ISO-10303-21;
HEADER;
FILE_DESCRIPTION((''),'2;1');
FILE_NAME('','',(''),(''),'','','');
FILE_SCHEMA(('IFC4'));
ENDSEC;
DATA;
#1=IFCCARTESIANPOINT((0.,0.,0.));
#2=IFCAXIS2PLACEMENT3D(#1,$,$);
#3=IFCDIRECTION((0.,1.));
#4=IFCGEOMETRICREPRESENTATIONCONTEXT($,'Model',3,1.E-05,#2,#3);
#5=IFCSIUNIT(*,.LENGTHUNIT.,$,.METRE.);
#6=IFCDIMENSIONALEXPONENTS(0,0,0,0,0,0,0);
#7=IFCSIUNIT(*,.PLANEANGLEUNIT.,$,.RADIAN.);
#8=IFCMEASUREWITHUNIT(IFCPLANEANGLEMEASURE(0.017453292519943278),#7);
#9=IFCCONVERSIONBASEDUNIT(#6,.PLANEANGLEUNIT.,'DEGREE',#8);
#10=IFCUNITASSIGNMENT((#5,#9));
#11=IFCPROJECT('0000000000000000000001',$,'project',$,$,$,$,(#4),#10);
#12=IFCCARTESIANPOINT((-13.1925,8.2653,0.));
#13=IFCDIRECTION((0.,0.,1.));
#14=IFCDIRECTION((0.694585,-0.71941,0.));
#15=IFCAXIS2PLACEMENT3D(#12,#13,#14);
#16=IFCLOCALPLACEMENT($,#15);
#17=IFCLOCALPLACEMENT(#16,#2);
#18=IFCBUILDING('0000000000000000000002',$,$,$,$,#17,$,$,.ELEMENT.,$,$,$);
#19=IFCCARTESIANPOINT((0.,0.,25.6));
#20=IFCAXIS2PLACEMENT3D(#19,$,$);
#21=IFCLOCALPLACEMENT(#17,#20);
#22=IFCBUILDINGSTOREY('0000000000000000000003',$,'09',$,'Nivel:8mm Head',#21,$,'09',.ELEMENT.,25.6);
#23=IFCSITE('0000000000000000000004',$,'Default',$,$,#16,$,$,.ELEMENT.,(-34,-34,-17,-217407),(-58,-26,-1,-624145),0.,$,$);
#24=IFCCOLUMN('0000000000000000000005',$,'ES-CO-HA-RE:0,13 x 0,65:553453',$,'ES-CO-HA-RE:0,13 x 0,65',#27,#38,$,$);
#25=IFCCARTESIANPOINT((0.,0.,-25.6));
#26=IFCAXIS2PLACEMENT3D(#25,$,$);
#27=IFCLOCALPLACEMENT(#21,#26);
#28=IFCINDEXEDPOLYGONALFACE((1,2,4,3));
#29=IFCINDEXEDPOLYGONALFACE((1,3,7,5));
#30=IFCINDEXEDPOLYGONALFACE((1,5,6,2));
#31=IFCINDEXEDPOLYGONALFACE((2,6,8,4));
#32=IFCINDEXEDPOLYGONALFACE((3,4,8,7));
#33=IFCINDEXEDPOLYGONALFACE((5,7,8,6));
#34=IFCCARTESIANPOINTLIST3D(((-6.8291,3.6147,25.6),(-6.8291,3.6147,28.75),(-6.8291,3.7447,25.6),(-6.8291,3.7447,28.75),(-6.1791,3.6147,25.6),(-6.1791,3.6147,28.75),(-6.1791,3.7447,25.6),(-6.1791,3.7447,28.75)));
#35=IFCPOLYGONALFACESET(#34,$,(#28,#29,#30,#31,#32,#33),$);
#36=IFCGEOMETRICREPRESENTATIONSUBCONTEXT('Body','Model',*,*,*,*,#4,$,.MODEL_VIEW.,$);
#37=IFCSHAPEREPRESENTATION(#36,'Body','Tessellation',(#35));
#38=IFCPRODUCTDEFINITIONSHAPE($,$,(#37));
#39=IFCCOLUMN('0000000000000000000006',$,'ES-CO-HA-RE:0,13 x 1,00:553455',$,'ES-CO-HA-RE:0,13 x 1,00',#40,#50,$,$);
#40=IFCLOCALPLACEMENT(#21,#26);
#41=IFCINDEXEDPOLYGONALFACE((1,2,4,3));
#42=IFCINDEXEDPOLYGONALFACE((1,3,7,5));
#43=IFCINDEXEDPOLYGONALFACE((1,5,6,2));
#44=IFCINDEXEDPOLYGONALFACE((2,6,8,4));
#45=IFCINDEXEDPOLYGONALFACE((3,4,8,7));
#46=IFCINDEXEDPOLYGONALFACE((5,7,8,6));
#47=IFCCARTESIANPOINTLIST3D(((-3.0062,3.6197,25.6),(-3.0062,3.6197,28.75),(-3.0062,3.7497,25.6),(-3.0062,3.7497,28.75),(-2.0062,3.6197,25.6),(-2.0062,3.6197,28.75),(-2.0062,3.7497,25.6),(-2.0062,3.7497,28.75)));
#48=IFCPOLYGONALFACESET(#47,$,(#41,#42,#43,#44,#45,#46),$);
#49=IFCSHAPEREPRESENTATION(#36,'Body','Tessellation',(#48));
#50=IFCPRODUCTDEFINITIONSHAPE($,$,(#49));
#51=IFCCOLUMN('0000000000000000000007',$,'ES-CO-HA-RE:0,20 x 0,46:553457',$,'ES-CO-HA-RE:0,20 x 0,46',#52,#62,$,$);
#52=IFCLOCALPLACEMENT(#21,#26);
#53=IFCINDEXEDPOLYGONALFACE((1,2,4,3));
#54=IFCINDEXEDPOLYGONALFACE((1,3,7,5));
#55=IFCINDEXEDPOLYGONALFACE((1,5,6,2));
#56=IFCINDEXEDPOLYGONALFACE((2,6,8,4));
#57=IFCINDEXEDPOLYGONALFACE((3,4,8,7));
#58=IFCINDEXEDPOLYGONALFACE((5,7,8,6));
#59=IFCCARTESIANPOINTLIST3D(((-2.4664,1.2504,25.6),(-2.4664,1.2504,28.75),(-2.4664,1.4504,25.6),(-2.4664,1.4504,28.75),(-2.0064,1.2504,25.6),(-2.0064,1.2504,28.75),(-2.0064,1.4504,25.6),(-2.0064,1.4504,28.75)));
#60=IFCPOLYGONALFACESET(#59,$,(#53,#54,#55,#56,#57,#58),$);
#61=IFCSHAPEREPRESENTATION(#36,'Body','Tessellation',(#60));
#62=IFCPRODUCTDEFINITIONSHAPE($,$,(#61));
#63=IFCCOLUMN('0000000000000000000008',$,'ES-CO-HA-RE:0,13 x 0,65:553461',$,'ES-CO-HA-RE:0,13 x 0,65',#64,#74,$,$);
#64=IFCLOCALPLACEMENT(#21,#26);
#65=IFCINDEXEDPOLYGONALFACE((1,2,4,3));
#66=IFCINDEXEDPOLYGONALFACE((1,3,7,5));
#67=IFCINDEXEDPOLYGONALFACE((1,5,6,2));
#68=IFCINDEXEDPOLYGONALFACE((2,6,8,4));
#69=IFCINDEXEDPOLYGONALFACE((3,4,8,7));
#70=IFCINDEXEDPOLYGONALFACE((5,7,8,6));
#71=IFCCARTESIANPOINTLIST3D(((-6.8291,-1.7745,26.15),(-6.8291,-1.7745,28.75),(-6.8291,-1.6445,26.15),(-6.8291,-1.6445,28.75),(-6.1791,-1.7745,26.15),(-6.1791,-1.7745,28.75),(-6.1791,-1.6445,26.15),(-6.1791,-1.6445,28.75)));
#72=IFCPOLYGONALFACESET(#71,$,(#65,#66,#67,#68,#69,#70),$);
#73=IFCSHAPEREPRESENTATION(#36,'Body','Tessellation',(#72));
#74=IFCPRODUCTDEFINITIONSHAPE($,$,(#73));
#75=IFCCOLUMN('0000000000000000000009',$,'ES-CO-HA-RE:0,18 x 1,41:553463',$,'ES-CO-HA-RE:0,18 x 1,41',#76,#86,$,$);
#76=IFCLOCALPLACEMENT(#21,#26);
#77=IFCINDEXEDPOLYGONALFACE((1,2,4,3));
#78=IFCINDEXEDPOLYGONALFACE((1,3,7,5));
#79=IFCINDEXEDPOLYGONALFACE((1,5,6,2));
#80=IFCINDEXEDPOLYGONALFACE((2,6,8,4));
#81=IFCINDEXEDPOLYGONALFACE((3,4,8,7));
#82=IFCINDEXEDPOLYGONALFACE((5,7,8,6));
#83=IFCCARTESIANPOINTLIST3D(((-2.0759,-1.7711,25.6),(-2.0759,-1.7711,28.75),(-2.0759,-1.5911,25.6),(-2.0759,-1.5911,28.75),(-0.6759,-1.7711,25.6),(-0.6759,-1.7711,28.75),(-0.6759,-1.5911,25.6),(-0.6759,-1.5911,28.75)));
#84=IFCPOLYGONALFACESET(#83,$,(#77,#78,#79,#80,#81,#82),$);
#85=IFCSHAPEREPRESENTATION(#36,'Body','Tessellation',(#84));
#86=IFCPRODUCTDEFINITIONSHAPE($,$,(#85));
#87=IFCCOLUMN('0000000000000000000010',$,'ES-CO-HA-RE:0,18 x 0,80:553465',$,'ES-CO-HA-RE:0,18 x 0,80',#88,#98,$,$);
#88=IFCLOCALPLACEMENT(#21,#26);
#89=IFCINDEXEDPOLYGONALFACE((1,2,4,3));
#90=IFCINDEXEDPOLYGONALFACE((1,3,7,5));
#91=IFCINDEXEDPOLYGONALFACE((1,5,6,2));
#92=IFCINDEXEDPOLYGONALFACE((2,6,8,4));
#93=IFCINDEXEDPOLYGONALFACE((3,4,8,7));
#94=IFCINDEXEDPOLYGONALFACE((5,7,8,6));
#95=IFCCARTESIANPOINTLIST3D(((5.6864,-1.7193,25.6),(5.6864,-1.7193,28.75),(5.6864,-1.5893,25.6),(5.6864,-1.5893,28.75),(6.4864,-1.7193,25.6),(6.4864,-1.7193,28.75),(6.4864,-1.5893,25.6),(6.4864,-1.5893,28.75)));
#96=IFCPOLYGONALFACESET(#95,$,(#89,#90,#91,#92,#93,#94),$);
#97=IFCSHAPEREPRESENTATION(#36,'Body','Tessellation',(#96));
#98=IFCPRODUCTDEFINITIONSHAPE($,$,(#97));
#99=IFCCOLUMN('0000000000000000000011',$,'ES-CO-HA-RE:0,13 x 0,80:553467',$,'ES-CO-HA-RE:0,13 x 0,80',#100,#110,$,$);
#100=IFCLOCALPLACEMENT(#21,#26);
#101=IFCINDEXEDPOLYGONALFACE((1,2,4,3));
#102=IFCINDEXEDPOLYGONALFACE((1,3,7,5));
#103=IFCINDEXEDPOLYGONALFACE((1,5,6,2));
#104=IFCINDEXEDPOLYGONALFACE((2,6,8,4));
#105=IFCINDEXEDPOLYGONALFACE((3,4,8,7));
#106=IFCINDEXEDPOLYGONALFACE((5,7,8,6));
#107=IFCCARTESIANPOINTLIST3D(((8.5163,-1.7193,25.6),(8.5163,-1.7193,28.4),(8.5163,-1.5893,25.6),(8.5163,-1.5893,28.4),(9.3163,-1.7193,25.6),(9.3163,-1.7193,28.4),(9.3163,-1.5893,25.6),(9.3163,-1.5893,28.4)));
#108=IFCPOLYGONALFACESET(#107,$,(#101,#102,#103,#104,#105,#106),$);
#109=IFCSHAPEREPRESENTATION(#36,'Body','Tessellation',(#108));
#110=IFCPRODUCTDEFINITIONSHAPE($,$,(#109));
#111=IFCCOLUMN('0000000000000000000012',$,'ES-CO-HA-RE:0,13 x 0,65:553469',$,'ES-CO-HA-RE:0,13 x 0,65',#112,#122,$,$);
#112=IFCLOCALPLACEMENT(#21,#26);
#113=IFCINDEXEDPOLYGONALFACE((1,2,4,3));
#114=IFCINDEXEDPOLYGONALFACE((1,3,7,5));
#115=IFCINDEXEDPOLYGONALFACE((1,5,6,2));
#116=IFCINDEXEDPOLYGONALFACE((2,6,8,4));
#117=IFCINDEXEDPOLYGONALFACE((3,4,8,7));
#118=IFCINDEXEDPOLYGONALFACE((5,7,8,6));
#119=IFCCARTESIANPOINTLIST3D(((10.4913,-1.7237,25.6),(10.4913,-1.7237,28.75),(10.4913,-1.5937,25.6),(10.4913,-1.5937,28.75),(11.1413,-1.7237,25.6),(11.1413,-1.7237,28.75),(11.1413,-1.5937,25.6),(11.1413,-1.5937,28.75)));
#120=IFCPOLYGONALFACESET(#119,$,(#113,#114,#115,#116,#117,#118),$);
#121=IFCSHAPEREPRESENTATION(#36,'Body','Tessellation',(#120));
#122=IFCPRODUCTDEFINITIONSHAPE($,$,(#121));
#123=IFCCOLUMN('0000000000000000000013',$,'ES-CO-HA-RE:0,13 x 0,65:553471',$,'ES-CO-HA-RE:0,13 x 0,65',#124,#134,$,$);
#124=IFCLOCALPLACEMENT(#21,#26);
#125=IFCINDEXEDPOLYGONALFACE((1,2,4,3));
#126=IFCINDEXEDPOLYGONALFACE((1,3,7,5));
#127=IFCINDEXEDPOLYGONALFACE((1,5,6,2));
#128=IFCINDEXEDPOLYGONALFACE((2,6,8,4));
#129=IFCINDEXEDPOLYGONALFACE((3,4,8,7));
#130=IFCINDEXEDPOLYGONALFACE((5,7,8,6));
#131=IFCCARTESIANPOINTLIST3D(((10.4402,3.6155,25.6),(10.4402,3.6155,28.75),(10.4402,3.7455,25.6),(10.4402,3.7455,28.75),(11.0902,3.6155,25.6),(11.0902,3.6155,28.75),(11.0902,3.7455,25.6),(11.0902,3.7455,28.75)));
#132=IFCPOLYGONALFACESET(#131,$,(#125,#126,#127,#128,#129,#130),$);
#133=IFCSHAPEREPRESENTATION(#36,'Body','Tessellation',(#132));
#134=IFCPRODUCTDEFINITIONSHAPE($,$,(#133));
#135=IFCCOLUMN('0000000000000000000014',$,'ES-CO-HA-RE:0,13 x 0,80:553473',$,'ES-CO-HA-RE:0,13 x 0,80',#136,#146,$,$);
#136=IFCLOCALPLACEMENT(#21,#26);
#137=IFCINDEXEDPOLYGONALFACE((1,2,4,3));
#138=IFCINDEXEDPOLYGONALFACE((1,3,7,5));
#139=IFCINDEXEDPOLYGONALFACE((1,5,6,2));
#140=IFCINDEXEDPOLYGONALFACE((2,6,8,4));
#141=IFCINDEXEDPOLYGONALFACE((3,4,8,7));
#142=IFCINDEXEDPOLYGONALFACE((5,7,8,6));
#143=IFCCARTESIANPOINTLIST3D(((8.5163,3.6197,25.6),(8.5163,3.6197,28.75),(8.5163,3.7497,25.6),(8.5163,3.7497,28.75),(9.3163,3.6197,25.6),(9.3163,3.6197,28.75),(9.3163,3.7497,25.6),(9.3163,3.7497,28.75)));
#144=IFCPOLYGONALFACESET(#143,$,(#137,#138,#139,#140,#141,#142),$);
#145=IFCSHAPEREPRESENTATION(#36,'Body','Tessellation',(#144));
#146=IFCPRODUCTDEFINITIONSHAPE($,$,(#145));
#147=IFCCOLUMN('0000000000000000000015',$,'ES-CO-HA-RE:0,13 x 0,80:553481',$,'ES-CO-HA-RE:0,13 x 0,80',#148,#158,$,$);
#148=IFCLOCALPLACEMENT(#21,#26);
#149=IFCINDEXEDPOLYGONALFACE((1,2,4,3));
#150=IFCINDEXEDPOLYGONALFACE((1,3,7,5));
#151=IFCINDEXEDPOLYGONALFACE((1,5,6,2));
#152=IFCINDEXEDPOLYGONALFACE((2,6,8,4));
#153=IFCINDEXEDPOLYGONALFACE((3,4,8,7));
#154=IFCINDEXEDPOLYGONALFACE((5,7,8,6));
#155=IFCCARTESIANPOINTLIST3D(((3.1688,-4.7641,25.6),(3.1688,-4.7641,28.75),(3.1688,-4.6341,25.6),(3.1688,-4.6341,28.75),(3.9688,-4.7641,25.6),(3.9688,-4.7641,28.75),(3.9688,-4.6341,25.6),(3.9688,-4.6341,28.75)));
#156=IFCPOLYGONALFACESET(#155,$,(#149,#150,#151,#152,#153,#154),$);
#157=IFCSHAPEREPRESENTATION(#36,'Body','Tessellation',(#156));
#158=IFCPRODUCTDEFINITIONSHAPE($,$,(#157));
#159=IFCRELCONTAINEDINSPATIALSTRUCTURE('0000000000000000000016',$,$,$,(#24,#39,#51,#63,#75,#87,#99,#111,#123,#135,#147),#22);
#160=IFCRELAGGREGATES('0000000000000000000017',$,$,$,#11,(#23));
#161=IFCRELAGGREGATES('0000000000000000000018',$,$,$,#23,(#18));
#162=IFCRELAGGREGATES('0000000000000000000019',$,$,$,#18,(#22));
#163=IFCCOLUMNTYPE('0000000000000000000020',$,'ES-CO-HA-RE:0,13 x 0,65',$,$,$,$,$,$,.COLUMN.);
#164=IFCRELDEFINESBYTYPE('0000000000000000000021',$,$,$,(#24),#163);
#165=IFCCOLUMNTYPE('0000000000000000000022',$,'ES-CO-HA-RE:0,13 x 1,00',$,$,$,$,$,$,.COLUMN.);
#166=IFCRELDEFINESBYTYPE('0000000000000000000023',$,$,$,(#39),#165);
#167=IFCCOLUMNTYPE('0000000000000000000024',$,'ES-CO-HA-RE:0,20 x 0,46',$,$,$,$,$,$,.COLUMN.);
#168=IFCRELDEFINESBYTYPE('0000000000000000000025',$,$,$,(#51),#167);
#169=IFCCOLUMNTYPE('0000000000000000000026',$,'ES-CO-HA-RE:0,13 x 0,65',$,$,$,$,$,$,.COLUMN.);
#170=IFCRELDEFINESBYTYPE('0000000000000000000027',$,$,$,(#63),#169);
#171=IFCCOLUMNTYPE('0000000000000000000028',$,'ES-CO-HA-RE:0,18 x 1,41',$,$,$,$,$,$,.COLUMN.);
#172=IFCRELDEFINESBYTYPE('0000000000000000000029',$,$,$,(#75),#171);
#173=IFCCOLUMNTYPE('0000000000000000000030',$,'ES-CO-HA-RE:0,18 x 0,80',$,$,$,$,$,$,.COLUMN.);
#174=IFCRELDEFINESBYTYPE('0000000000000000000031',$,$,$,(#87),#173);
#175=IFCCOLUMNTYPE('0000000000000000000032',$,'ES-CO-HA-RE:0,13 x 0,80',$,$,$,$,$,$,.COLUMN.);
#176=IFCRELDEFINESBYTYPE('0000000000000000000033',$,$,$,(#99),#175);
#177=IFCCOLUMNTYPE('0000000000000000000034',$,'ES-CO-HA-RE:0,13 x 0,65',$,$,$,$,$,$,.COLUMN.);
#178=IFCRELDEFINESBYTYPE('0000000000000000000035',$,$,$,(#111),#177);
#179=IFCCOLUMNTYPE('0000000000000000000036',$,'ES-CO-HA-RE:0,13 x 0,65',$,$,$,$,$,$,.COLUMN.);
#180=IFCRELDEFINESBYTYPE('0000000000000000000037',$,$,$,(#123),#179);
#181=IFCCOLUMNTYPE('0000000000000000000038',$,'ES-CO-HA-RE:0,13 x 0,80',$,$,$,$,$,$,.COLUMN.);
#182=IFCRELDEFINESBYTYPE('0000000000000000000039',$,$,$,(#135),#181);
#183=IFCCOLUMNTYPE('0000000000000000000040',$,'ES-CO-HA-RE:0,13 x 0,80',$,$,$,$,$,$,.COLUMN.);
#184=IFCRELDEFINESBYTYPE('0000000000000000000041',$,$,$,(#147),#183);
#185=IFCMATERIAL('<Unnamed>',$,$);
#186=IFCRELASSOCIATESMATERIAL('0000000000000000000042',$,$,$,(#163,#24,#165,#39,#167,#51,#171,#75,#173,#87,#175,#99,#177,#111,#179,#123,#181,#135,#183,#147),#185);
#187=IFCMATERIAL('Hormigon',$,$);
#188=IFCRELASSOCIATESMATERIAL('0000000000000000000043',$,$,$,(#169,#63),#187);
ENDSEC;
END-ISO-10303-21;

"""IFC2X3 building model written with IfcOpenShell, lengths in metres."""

from ifc_helpers import new_model, entity, si_unit, converted_unit, direction, frame, frame_2d, origin, origin_2d_with_axis, place, context, subcontext, project, spatial, rectangle, extrude, source, transform, mapped, material, type_object, type_shapes, element, save


model = new_model("IFC2X3")

# Units and contexts
model_context = context("Model", 3, precision=1e-05, world=origin(), true_north=direction((0.0, 1.0)))
body_context = subcontext(model_context, "Body", "Model", "MODEL_VIEW")
ifc_project = project(units=[si_unit("LENGTHUNIT", "METRE"), converted_unit("PLANEANGLEUNIT", "DEGREE", entity("IfcPlaneAngleMeasure", 0.017453292519943278), si_unit("PLANEANGLEUNIT", "RADIAN"), dimensions=[0, 0, 0, 0, 0, 0, 0])], contexts=[model_context])

# Site, building, storey
site_placement = place(None, frame((-13.1925, 8.2653, 0.0), z_axis=(0.0, 0.0, 1.0), x_axis=(0.694585, -0.71941, 0.0)))
site = spatial("IfcSite", under=ifc_project, at=site_placement, Name="Default", CompositionType="ELEMENT", RefLatitude=(-34, -34, -17, -217407), RefLongitude=(-58, -26, -1, -624145), RefElevation=0.0)
building_placement = place(site_placement, origin())
building = spatial("IfcBuilding", under=site, at=building_placement, CompositionType="ELEMENT")
storey_placement = place(building_placement, frame((0.0, 0.0, 25.6)))
storey = spatial("IfcBuildingStorey", under=building, at=storey_placement, Name="09", ObjectType="Nivel:8mm Head", LongName="09", CompositionType="ELEMENT", Elevation=25.6)

# Columns
ifc_material_1 = material(Name="<Unnamed>")
column_type_1 = type_object("IfcColumnType", Name="ES-CO-HA-RE:0,13 x 0,65", PredefinedType="COLUMN", material=ifc_material_1)
shared_shape_1 = source(origin(), body_context, "Body", "SweptSolid", [
    extrude(rectangle(XDim=0.65, YDim=0.13, at=origin_2d_with_axis()), frame((-6.5041, 3.6797, 25.6), z_axis=(0.0, 0.0, 1.0), x_axis=(-1.0, 0.0, 0.0)), (0.0, 0.0, 1.0), 3.15),
])
type_shapes(column_type_1, [shared_shape_1])
column_1_placement = place(storey_placement, frame((0.0, 0.0, -25.6)))
element("IfcColumn", 1, at=column_1_placement, inside=storey, type_object=column_type_1, material=ifc_material_1, Name="ES-CO-HA-RE:0,13 x 0,65:553453", ObjectType="ES-CO-HA-RE:0,13 x 0,65", context=body_context, shape_type="MappedRepresentation", body=[
    mapped(shared_shape_1, transform((0.0, 0.0, 0.0), scale=1.0)),
])
column_type_2 = type_object("IfcColumnType", Name="ES-CO-HA-RE:0,13 x 1,00", PredefinedType="COLUMN", material=ifc_material_1)
shared_shape_2 = source(origin(), body_context, "Body", "SweptSolid", [
    extrude(rectangle(XDim=1.0, YDim=0.13, at=frame_2d((0.0, 0.0), x_axis=(1.0, 0.0))), frame((-2.5062, 3.6847, 25.6), z_axis=(0.0, 0.0, 1.0), x_axis=(-1.0, 0.0, 0.0)), (0.0, 0.0, 1.0), 3.15),
])
type_shapes(column_type_2, [shared_shape_2])
column_2_placement = place(storey_placement, frame((0.0, 0.0, -25.6)))
element("IfcColumn", 2, at=column_2_placement, inside=storey, type_object=column_type_2, material=ifc_material_1, Name="ES-CO-HA-RE:0,13 x 1,00:553455", ObjectType="ES-CO-HA-RE:0,13 x 1,00", context=body_context, shape_type="MappedRepresentation", body=[
    mapped(shared_shape_2, transform((0.0, 0.0, 0.0), scale=1.0)),
])
column_type_3 = type_object("IfcColumnType", Name="ES-CO-HA-RE:0,20 x 0,46", PredefinedType="COLUMN", material=ifc_material_1)
shared_shape_3 = source(origin(), body_context, "Body", "SweptSolid", [
    extrude(rectangle(XDim=0.46, YDim=0.2, at=frame_2d((0.0, 0.0), x_axis=(1.0, 0.0))), frame((-2.2364, 1.3504, 25.6), z_axis=(0.0, 0.0, 1.0), x_axis=(-1.0, 0.0, 0.0)), (0.0, 0.0, 1.0), 3.15),
])
type_shapes(column_type_3, [shared_shape_3])
column_3_placement = place(storey_placement, frame((0.0, 0.0, -25.6)))
element("IfcColumn", 3, at=column_3_placement, inside=storey, type_object=column_type_3, material=ifc_material_1, Name="ES-CO-HA-RE:0,20 x 0,46:553457", ObjectType="ES-CO-HA-RE:0,20 x 0,46", context=body_context, shape_type="MappedRepresentation", body=[
    mapped(shared_shape_3, transform((0.0, 0.0, 0.0), scale=1.0)),
])
ifc_material_2 = material(Name="Hormigon")
column_type_4 = type_object("IfcColumnType", Name="ES-CO-HA-RE:0,13 x 0,65", PredefinedType="COLUMN", material=ifc_material_2)
shared_shape_4 = source(origin(), body_context, "Body", "SweptSolid", [
    extrude(rectangle(XDim=0.65, YDim=0.13, at=frame_2d((0.0, 0.0), x_axis=(1.0, 0.0))), frame((-6.5041, -1.7095, 26.15), z_axis=(0.0, 0.0, 1.0), x_axis=(-1.0, 0.0, 0.0)), (0.0, 0.0, 1.0), 2.6),
])
type_shapes(column_type_4, [shared_shape_4])
column_4_placement = place(storey_placement, frame((0.0, 0.0, -25.6)))
element("IfcColumn", 4, at=column_4_placement, inside=storey, type_object=column_type_4, material=ifc_material_2, Name="ES-CO-HA-RE:0,13 x 0,65:553461", ObjectType="ES-CO-HA-RE:0,13 x 0,65", context=body_context, shape_type="MappedRepresentation", body=[
    mapped(shared_shape_4, transform((0.0, 0.0, 0.0), scale=1.0)),
])
column_type_5 = type_object("IfcColumnType", Name="ES-CO-HA-RE:0,18 x 1,41", PredefinedType="COLUMN", material=ifc_material_1)
shared_shape_5 = source(origin(), body_context, "Body", "SweptSolid", [
    extrude(rectangle(XDim=1.4, YDim=0.18, at=frame_2d((0.0, 0.0), x_axis=(1.0, 0.0))), frame((-1.3759, -1.6811, 25.6), z_axis=(0.0, 0.0, 1.0), x_axis=(-1.0, 0.0, 0.0)), (0.0, 0.0, 1.0), 3.15),
])
type_shapes(column_type_5, [shared_shape_5])
column_5_placement = place(storey_placement, frame((0.0, 0.0, -25.6)))
element("IfcColumn", 5, at=column_5_placement, inside=storey, type_object=column_type_5, material=ifc_material_1, Name="ES-CO-HA-RE:0,18 x 1,41:553463", ObjectType="ES-CO-HA-RE:0,18 x 1,41", context=body_context, shape_type="MappedRepresentation", body=[
    mapped(shared_shape_5, transform((0.0, 0.0, 0.0), scale=1.0)),
])
column_type_6 = type_object("IfcColumnType", Name="ES-CO-HA-RE:0,18 x 0,80", PredefinedType="COLUMN", material=ifc_material_1)
shared_shape_6 = source(origin(), body_context, "Body", "SweptSolid", [
    extrude(rectangle(XDim=0.8, YDim=0.13, at=frame_2d((0.0, 0.0), x_axis=(1.0, 0.0))), frame((6.0864, -1.6543, 25.6), z_axis=(0.0, 0.0, 1.0), x_axis=(-1.0, 0.0, 0.0)), (0.0, 0.0, 1.0), 3.15),
])
type_shapes(column_type_6, [shared_shape_6])
column_6_placement = place(storey_placement, frame((0.0, 0.0, -25.6)))
element("IfcColumn", 6, at=column_6_placement, inside=storey, type_object=column_type_6, material=ifc_material_1, Name="ES-CO-HA-RE:0,18 x 0,80:553465", ObjectType="ES-CO-HA-RE:0,18 x 0,80", context=body_context, shape_type="MappedRepresentation", body=[
    mapped(shared_shape_6, transform((0.0, 0.0, 0.0), scale=1.0)),
])
column_type_7 = type_object("IfcColumnType", Name="ES-CO-HA-RE:0,13 x 0,80", PredefinedType="COLUMN", material=ifc_material_1)
shared_shape_7 = source(origin(), body_context, "Body", "SweptSolid", [
    extrude(rectangle(XDim=0.8, YDim=0.13, at=frame_2d((0.0, 0.0), x_axis=(1.0, 0.0))), frame((8.9163, -1.6543, 25.6), z_axis=(0.0, 0.0, 1.0), x_axis=(-1.0, 0.0, 0.0)), (0.0, 0.0, 1.0), 2.8),
])
type_shapes(column_type_7, [shared_shape_7])
column_7_placement = place(storey_placement, frame((0.0, 0.0, -25.6)))
element("IfcColumn", 7, at=column_7_placement, inside=storey, type_object=column_type_7, material=ifc_material_1, Name="ES-CO-HA-RE:0,13 x 0,80:553467", ObjectType="ES-CO-HA-RE:0,13 x 0,80", context=body_context, shape_type="MappedRepresentation", body=[
    mapped(shared_shape_7, transform((0.0, 0.0, 0.0), scale=1.0)),
])
column_type_8 = type_object("IfcColumnType", Name="ES-CO-HA-RE:0,13 x 0,65", PredefinedType="COLUMN", material=ifc_material_1)
shared_shape_8 = source(origin(), body_context, "Body", "SweptSolid", [
    extrude(rectangle(XDim=0.65, YDim=0.13, at=origin_2d_with_axis()), frame((10.8163, -1.6587, 25.6), z_axis=(0.0, 0.0, 1.0), x_axis=(-1.0, 0.0, 0.0)), (0.0, 0.0, 1.0), 3.15),
])
type_shapes(column_type_8, [shared_shape_8])
column_8_placement = place(storey_placement, frame((0.0, 0.0, -25.6)))
element("IfcColumn", 8, at=column_8_placement, inside=storey, type_object=column_type_8, material=ifc_material_1, Name="ES-CO-HA-RE:0,13 x 0,65:553469", ObjectType="ES-CO-HA-RE:0,13 x 0,65", context=body_context, shape_type="MappedRepresentation", body=[
    mapped(shared_shape_8, transform((0.0, 0.0, 0.0), scale=1.0)),
])
column_type_9 = type_object("IfcColumnType", Name="ES-CO-HA-RE:0,13 x 0,65", PredefinedType="COLUMN", material=ifc_material_1)
shared_shape_9 = source(origin(), body_context, "Body", "SweptSolid", [
    extrude(rectangle(XDim=0.65, YDim=0.13, at=origin_2d_with_axis()), frame((10.7652, 3.6805, 25.6), z_axis=(0.0, 0.0, 1.0), x_axis=(-1.0, 0.0, 0.0)), (0.0, 0.0, 1.0), 3.15),
])
type_shapes(column_type_9, [shared_shape_9])
column_9_placement = place(storey_placement, frame((0.0, 0.0, -25.6)))
element("IfcColumn", 9, at=column_9_placement, inside=storey, type_object=column_type_9, material=ifc_material_1, Name="ES-CO-HA-RE:0,13 x 0,65:553471", ObjectType="ES-CO-HA-RE:0,13 x 0,65", context=body_context, shape_type="MappedRepresentation", body=[
    mapped(shared_shape_9, transform((0.0, 0.0, 0.0), scale=1.0)),
])
column_type_10 = type_object("IfcColumnType", Name="ES-CO-HA-RE:0,13 x 0,80", PredefinedType="COLUMN", material=ifc_material_1)
shared_shape_10 = source(origin(), body_context, "Body", "SweptSolid", [
    extrude(rectangle(XDim=0.8, YDim=0.13, at=origin_2d_with_axis()), frame((8.9163, 3.6847, 25.6), z_axis=(0.0, 0.0, 1.0), x_axis=(-1.0, 0.0, 0.0)), (0.0, 0.0, 1.0), 3.15),
])
type_shapes(column_type_10, [shared_shape_10])
column_10_placement = place(storey_placement, frame((0.0, 0.0, -25.6)))
element("IfcColumn", 10, at=column_10_placement, inside=storey, type_object=column_type_10, material=ifc_material_1, Name="ES-CO-HA-RE:0,13 x 0,80:553473", ObjectType="ES-CO-HA-RE:0,13 x 0,80", context=body_context, shape_type="MappedRepresentation", body=[
    mapped(shared_shape_10, transform((0.0, 0.0, 0.0), scale=1.0)),
])
column_type_11 = type_object("IfcColumnType", Name="ES-CO-HA-RE:0,13 x 0,80", PredefinedType="COLUMN", material=ifc_material_1)
shared_shape_11 = source(origin(), body_context, "Body", "SweptSolid", [
    extrude(rectangle(XDim=0.8, YDim=0.13, at=frame_2d((0.0, 0.0), x_axis=(1.0, 0.0))), frame((3.5688, -4.6991, 25.6), z_axis=(0.0, 0.0, 1.0), x_axis=(-1.0, 0.0, 0.0)), (0.0, 0.0, 1.0), 3.15),
])
type_shapes(column_type_11, [shared_shape_11])
column_11_placement = place(storey_placement, frame((0.0, 0.0, -25.6)))
element("IfcColumn", 11, at=column_11_placement, inside=storey, type_object=column_type_11, material=ifc_material_1, Name="ES-CO-HA-RE:0,13 x 0,80:553481", ObjectType="ES-CO-HA-RE:0,13 x 0,80", context=body_context, shape_type="MappedRepresentation", body=[
    mapped(shared_shape_11, transform((0.0, 0.0, 0.0), scale=1.0)),
])

save(model, "model.ifc")
